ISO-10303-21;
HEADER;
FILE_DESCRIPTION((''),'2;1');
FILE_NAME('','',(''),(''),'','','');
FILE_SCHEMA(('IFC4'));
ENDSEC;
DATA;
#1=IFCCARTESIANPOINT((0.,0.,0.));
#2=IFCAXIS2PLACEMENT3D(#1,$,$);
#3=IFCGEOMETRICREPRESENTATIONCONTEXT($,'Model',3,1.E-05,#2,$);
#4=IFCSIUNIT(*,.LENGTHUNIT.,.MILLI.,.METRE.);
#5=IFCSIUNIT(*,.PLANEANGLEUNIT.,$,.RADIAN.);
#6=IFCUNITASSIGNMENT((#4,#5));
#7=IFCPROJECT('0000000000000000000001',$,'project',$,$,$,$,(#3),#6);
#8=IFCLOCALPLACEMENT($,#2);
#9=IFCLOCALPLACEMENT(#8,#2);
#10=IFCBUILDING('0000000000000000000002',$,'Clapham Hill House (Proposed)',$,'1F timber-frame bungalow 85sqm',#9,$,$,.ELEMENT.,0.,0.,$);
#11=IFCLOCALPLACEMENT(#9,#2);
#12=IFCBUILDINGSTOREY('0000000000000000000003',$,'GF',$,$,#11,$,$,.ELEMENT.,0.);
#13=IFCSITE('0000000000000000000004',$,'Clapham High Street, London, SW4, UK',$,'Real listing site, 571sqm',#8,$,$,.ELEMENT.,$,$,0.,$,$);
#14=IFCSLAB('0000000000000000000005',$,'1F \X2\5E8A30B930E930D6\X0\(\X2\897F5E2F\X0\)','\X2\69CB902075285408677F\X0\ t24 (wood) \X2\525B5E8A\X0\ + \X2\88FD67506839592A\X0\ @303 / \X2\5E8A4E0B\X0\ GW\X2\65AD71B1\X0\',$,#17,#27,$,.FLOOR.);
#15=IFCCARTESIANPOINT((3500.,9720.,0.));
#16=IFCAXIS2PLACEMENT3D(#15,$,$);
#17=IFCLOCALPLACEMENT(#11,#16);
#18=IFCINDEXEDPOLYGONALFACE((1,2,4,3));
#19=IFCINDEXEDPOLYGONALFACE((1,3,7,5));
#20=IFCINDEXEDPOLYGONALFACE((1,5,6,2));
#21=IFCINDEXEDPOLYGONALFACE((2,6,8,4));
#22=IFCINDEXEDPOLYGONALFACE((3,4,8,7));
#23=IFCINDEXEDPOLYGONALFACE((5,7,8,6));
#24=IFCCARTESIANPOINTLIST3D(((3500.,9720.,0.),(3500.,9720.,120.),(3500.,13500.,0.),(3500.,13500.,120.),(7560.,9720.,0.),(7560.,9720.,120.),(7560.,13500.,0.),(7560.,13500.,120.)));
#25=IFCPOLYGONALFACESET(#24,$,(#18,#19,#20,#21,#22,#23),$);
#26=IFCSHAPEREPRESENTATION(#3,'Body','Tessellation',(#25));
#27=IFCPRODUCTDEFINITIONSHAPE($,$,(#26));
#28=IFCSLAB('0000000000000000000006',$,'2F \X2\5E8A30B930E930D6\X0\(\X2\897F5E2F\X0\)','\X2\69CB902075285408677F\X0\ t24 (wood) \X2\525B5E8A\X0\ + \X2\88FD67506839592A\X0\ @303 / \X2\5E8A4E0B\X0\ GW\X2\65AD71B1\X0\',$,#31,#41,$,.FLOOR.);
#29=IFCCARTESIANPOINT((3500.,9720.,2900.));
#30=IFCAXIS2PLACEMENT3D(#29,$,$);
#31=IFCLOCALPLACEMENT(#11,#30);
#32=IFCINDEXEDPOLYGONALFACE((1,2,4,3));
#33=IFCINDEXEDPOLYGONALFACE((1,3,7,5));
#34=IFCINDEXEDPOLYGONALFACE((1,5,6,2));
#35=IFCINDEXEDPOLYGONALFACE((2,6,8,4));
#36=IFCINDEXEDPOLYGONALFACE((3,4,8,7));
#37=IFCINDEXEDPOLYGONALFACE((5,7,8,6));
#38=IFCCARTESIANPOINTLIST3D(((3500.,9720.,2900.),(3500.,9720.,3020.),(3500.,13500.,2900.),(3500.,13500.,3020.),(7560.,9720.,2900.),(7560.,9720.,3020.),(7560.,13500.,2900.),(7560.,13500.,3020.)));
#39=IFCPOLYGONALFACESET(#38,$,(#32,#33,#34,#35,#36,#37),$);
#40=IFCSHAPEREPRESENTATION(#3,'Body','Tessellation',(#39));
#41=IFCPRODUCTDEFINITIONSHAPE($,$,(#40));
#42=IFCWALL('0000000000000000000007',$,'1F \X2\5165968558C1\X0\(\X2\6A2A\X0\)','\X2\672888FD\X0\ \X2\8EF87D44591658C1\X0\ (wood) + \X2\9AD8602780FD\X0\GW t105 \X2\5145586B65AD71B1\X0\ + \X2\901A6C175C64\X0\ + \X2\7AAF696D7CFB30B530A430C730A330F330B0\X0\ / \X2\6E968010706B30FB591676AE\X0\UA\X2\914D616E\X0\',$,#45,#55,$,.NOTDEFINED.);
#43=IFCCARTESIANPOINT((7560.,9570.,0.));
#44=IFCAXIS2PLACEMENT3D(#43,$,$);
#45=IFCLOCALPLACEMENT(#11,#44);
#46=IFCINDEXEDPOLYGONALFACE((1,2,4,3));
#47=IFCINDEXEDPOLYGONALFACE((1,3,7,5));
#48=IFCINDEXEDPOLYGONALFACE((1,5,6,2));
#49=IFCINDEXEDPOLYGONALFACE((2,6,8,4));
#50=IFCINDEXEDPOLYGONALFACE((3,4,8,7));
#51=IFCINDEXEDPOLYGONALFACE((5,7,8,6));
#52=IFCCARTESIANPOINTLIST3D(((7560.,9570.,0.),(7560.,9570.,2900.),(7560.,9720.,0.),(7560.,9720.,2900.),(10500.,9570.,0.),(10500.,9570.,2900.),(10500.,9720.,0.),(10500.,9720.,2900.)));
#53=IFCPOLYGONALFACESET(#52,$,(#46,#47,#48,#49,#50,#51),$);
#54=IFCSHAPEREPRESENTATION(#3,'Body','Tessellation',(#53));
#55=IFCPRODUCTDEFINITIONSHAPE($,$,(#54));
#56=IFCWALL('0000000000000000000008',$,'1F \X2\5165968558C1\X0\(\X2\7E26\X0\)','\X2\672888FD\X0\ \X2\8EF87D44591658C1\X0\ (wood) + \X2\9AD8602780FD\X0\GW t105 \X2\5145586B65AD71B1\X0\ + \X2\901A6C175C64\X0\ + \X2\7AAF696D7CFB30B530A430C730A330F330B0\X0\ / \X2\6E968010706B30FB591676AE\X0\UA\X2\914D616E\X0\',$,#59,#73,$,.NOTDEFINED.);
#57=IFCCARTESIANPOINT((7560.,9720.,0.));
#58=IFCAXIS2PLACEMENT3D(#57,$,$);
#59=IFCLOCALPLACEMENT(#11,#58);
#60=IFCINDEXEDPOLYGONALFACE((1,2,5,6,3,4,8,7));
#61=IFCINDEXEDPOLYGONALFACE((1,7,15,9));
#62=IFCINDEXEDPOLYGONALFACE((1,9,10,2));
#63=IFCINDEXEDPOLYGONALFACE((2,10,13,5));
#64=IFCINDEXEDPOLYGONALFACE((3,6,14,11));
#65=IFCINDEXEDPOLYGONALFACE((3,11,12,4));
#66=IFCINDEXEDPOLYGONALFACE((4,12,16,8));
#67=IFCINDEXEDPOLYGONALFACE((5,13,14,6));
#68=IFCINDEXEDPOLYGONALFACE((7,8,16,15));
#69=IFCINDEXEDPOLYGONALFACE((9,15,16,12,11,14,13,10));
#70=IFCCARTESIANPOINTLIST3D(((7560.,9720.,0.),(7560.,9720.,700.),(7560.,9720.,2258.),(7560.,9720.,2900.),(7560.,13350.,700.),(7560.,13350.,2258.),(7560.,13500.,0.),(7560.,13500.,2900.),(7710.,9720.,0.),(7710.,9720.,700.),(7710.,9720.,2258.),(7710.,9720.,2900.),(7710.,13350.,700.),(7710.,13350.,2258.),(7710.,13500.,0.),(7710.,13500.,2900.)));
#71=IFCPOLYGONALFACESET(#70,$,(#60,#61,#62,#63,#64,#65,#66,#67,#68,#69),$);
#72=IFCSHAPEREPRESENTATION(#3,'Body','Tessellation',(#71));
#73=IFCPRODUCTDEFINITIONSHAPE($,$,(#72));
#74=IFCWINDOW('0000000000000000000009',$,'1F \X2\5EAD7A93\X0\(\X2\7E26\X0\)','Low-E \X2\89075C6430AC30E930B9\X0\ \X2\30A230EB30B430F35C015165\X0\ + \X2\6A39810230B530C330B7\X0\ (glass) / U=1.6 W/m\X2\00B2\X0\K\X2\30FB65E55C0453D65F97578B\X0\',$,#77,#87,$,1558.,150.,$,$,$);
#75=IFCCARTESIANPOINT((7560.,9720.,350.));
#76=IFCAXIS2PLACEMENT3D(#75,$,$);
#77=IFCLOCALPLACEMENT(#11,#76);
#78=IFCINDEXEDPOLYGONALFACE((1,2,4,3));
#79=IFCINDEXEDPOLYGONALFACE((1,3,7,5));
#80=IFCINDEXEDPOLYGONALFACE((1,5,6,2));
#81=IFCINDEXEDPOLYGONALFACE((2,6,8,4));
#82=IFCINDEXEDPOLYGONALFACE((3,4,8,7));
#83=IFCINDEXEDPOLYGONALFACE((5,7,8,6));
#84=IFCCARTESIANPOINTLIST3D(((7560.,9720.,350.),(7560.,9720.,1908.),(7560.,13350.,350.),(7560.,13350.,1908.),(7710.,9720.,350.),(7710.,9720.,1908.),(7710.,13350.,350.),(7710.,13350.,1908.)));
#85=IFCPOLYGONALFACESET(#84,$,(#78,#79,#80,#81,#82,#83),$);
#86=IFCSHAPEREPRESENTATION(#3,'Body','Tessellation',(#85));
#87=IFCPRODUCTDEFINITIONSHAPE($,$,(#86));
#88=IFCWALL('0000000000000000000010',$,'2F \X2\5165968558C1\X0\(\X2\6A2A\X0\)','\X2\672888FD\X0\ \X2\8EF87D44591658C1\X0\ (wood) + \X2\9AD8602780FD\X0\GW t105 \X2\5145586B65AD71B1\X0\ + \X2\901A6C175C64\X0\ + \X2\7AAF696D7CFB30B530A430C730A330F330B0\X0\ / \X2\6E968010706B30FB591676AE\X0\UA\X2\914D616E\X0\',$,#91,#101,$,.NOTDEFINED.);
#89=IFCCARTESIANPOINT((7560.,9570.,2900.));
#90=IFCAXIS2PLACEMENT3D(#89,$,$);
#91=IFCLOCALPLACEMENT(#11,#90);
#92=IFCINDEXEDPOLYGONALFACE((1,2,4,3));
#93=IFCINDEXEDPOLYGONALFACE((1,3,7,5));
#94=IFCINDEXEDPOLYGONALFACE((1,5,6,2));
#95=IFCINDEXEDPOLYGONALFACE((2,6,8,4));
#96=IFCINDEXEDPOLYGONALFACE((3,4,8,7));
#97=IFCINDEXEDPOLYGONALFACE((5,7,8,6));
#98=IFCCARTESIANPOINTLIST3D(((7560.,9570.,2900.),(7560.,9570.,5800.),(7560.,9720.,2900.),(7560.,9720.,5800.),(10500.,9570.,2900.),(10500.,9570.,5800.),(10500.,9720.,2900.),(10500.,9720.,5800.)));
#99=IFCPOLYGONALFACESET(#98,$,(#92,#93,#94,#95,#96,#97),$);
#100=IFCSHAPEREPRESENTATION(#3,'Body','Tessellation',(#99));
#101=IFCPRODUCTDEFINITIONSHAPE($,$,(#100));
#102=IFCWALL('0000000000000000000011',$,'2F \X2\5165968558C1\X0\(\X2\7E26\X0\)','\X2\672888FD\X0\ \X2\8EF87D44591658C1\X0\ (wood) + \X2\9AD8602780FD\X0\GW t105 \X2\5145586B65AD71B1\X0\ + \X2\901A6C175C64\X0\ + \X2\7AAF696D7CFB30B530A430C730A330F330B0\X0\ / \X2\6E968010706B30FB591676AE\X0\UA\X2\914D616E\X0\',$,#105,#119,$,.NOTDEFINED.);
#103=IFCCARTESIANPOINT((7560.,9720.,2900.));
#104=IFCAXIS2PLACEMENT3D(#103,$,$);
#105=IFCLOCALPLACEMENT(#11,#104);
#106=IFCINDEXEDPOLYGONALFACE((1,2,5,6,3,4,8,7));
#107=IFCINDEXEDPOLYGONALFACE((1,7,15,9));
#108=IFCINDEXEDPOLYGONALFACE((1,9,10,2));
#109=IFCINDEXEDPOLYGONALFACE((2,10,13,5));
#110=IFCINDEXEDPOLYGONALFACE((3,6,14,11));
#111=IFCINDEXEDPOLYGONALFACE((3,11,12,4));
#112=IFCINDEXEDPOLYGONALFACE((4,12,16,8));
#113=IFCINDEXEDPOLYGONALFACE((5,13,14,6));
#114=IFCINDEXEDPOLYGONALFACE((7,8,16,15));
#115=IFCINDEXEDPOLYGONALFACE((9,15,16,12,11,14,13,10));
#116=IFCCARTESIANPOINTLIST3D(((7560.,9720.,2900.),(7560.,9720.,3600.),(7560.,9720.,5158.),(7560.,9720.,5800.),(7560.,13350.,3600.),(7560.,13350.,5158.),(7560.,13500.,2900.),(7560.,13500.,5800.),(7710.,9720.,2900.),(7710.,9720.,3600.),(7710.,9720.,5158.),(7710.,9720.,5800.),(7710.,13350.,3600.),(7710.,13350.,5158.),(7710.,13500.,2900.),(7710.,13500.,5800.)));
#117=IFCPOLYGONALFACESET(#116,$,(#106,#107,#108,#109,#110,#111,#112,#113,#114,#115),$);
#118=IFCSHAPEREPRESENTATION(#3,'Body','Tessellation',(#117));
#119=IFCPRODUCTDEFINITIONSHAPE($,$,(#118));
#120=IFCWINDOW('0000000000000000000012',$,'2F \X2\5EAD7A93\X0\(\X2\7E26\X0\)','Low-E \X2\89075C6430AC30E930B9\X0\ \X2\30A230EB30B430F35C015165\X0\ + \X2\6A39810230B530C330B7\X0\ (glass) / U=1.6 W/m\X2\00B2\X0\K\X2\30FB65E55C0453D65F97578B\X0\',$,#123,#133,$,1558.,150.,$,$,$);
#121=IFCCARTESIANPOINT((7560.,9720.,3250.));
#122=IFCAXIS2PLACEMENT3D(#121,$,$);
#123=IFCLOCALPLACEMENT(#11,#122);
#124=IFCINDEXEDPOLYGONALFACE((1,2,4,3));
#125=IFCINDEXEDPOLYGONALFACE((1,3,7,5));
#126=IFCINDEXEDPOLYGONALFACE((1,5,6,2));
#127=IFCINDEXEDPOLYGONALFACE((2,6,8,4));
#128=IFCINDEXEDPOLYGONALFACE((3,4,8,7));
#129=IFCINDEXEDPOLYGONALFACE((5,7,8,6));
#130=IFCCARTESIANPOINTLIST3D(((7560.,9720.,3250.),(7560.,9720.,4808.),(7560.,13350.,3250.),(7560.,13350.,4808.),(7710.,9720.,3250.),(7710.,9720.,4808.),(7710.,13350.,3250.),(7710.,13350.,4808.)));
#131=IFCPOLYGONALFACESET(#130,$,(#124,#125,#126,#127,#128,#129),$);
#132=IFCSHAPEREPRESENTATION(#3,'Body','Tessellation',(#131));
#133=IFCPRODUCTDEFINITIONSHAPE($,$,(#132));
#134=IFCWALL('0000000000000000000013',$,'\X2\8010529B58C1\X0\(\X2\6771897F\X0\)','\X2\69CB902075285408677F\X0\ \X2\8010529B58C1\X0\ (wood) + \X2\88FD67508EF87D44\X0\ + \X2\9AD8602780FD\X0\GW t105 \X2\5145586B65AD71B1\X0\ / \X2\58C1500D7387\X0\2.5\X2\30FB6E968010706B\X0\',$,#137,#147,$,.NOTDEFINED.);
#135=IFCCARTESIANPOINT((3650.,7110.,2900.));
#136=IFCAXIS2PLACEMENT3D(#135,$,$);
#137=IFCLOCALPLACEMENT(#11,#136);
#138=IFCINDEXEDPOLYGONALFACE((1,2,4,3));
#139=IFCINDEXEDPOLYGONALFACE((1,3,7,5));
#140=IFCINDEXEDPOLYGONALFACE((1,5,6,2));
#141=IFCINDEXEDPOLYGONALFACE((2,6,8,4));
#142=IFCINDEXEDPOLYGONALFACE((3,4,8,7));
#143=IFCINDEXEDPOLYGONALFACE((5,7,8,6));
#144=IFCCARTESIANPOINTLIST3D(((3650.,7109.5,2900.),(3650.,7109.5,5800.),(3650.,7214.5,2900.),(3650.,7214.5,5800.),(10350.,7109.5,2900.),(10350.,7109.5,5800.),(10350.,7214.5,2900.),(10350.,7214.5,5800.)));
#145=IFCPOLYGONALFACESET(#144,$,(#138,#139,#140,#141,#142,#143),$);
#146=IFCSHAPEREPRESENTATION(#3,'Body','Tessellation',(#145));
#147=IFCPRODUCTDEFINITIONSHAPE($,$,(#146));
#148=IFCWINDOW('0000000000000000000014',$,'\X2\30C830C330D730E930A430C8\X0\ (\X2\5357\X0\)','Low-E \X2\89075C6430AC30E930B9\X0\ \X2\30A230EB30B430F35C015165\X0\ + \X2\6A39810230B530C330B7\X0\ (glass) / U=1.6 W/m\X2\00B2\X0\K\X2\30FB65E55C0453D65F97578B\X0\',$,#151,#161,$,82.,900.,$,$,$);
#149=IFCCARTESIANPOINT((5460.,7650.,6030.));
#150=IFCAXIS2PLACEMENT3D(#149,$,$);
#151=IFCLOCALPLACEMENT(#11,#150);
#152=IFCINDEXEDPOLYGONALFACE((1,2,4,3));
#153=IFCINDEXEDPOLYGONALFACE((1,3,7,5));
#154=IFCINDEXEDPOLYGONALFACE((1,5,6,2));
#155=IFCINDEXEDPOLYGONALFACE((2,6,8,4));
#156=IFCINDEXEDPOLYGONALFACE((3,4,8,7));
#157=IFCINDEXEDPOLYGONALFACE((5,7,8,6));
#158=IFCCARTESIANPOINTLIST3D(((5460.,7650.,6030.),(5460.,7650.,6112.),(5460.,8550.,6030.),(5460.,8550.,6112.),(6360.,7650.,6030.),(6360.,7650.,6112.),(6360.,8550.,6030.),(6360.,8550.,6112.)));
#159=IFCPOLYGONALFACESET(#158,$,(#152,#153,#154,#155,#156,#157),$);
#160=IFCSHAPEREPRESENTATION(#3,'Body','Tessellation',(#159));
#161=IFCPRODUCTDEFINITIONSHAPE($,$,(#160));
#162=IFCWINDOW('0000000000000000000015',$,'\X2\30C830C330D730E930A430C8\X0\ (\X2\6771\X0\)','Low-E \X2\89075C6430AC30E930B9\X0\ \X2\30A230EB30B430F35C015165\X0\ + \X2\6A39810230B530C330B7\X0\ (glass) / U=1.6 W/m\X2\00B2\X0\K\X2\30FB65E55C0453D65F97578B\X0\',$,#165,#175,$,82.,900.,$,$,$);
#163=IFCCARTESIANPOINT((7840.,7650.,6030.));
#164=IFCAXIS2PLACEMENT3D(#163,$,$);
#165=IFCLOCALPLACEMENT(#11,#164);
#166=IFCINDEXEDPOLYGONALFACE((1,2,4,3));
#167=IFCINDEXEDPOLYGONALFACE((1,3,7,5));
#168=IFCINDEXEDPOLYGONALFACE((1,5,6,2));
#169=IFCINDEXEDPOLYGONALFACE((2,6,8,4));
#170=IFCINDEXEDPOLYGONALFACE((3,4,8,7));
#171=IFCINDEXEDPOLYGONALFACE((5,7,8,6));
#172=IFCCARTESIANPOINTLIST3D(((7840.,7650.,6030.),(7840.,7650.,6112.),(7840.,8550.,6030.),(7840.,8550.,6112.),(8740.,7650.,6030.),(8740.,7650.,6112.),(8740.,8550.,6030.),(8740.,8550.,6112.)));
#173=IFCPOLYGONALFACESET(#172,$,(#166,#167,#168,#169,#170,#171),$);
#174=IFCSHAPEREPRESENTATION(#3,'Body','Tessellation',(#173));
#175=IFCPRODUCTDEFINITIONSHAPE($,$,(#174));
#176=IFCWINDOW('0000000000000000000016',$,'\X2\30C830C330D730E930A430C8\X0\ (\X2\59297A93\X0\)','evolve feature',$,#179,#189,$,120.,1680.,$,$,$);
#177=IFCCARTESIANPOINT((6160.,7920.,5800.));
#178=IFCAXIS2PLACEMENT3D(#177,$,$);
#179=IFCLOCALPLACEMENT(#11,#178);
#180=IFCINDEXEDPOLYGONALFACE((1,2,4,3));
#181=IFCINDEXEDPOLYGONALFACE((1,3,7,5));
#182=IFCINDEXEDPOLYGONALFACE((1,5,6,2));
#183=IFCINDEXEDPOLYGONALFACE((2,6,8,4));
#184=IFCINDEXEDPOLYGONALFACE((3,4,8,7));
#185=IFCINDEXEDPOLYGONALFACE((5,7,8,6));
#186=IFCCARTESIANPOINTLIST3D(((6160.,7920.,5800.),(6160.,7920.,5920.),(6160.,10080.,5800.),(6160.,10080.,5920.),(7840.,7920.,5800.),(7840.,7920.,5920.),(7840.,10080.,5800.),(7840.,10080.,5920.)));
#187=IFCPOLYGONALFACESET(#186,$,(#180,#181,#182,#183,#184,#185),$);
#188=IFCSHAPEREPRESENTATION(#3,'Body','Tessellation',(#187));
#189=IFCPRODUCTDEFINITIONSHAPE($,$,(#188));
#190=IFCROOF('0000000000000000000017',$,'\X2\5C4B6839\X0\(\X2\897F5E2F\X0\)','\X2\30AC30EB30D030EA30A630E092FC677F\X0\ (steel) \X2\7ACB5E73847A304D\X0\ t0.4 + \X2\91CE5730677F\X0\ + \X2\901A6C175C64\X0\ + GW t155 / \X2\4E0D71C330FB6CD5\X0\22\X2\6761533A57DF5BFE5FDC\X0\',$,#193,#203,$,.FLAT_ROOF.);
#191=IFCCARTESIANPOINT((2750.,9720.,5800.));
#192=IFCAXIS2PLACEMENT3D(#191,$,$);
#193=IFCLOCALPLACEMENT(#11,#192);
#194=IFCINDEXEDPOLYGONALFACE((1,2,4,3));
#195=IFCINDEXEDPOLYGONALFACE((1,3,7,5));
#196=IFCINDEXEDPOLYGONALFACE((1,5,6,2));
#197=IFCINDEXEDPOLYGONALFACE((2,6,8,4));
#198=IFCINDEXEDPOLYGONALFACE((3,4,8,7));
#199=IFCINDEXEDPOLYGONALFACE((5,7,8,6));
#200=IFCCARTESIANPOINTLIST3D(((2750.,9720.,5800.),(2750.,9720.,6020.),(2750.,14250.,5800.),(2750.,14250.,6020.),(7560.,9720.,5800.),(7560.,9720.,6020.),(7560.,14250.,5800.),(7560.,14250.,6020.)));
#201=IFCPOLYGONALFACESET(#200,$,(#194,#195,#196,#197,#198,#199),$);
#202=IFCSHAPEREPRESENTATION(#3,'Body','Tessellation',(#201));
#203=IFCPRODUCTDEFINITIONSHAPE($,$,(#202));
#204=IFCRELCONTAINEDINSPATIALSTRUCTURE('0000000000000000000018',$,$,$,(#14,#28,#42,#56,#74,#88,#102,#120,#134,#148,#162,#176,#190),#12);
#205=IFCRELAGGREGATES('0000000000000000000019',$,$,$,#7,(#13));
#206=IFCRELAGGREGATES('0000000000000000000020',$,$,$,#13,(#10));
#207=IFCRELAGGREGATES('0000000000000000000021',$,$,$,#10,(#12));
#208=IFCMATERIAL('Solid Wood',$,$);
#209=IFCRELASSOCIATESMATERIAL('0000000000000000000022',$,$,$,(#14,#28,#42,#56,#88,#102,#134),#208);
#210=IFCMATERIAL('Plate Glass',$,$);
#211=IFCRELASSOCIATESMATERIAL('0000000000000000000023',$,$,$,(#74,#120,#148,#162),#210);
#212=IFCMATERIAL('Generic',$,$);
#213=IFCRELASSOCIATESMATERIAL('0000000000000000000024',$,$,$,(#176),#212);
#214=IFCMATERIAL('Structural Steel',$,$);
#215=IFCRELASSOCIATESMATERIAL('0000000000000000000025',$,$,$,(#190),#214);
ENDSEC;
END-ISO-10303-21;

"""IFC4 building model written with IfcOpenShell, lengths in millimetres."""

from ifc_helpers import new_model, si_unit, frame, frame_2d, origin, place, context, project, spatial, rectangle, extrude, material, element, fill, save


model = new_model("IFC4")

# Units and contexts
model_context = context("Model", 3, precision=1e-05, world=origin())
ifc_project = project(units=[si_unit("LENGTHUNIT", "METRE", prefix="MILLI"), si_unit("PLANEANGLEUNIT", "RADIAN")], contexts=[model_context])

# Site, building, storey
site_placement = place(None, origin())
site = spatial("IfcSite", under=ifc_project, at=site_placement, Name="Clapham High Street, London, SW4, UK", ObjectType="Real listing site, 571sqm", CompositionType="ELEMENT", RefElevation=0.0)
building_placement = place(site_placement, origin())
building = spatial("IfcBuilding", under=site, at=building_placement, Name="Clapham Hill House (Proposed)", ObjectType="1F timber-frame bungalow 85sqm", CompositionType="ELEMENT", ElevationOfRefHeight=0.0, ElevationOfTerrain=0.0)
storey_placement = place(building_placement, origin())
storey = spatial("IfcBuildingStorey", under=building, at=storey_placement, Name="GF", CompositionType="ELEMENT", Elevation=0.0)

# Slabs
ifc_material_1 = material(Name="Solid Wood")
slab_1_placement = place(storey_placement, frame((3500.0, 9720.0, 0.0)))
element("IfcSlab", 1, at=slab_1_placement, inside=storey, material=ifc_material_1, Name="1F 床スラブ(西帯)", Description="構造用合板 t24 (wood) 剛床 + 製材根太 @303 / 床下 GW断熱", PredefinedType="FLOOR", context=model_context, shape_type="SweptSolid", body=[
    extrude(rectangle(XDim=4060.0, YDim=3780.0, at=frame_2d((2030.0, 1890.0))), frame((3500.0, 9720.0, 0.0)), (0.0, 0.0, 1.0), 120.0),
])
slab_2_placement = place(storey_placement, frame((3500.0, 9720.0, 2900.0)))
element("IfcSlab", 2, at=slab_2_placement, inside=storey, material=ifc_material_1, Name="2F 床スラブ(西帯)", Description="構造用合板 t24 (wood) 剛床 + 製材根太 @303 / 床下 GW断熱", PredefinedType="FLOOR", context=model_context, shape_type="SweptSolid", body=[
    extrude(rectangle(XDim=4060.0, YDim=3780.0, at=frame_2d((2030.0, 1890.0))), frame((3500.0, 9720.0, 2900.0)), (0.0, 0.0, 1.0), 120.0),
])

# Wall
wall_1_placement = place(storey_placement, frame((7560.0, 9570.0, 0.0)))
element("IfcWall", 3, at=wall_1_placement, inside=storey, material=ifc_material_1, Name="1F 入隅壁(横)", Description="木製 軸組外壁 (wood) + 高性能GW t105 充填断熱 + 通気層 + 窯業系サイディング / 準耐火・外皮UA配慮", PredefinedType="NOTDEFINED", context=model_context, shape_type="SweptSolid", body=[
    extrude(rectangle(XDim=2940.0, YDim=150.0, at=frame_2d((1470.0, 75.0))), frame((7560.0, 9570.0, 0.0)), (0.0, 0.0, 1.0), 2900.0),
])

# Wall, opening, window
wall_2_placement = place(storey_placement, frame((7560.0, 9720.0, 0.0)))
wall_2 = element("IfcWall", 4, at=wall_2_placement, inside=storey, material=ifc_material_1, Name="1F 入隅壁(縦)", Description="木製 軸組外壁 (wood) + 高性能GW t105 充填断熱 + 通気層 + 窯業系サイディング / 準耐火・外皮UA配慮", PredefinedType="NOTDEFINED", context=model_context, shape_type="SweptSolid", body=[
    extrude(rectangle(XDim=150.0, YDim=3780.0, at=frame_2d((75.0, 1890.0))), frame((7560.0, 9720.0, 0.0)), (0.0, 0.0, 1.0), 2900.0),
])
opening_1_placement = place(storey_placement, frame((7560.0, 9720.0, 350.0)))
opening_1 = element("IfcOpeningElement", 5, at=opening_1_placement, cuts=wall_2, PredefinedType="NOTDEFINED", context=model_context, shape_type="SweptSolid", body=[
    extrude(rectangle(XDim=150.0, YDim=3630.0, at=frame_2d((75.0, 1815.0))), frame((7560.0, 9720.0, 350.0)), (0.0, 0.0, 1.0), 1558.0),
])
ifc_material_2 = material(Name="Plate Glass")
window_1_placement = place(storey_placement, frame((7560.0, 9720.0, 350.0)))
window_1 = element("IfcWindow", 6, at=window_1_placement, inside=storey, material=ifc_material_2, Name="1F 庭窓(縦)", Description="Low-E 複層ガラス アルゴン封入 + 樹脂サッシ (glass) / U=1.6 W/m²K・日射取得型", OverallHeight=1558.0, OverallWidth=150.0, context=model_context, shape_type="SweptSolid", body=[
    extrude(rectangle(XDim=150.0, YDim=3630.0, at=frame_2d((75.0, 1815.0))), frame((7560.0, 9720.0, 350.0)), (0.0, 0.0, 1.0), 1558.0),
])
fill(opening_1, window_1)

# Wall
wall_3_placement = place(storey_placement, frame((7560.0, 9570.0, 2900.0)))
element("IfcWall", 7, at=wall_3_placement, inside=storey, material=ifc_material_1, Name="2F 入隅壁(横)", Description="木製 軸組外壁 (wood) + 高性能GW t105 充填断熱 + 通気層 + 窯業系サイディング / 準耐火・外皮UA配慮", PredefinedType="NOTDEFINED", context=model_context, shape_type="SweptSolid", body=[
    extrude(rectangle(XDim=2940.0, YDim=150.0, at=frame_2d((1470.0, 75.0))), frame((7560.0, 9570.0, 2900.0)), (0.0, 0.0, 1.0), 2900.0),
])

# Wall, opening, window
wall_4_placement = place(storey_placement, frame((7560.0, 9720.0, 2900.0)))
wall_4 = element("IfcWall", 8, at=wall_4_placement, inside=storey, material=ifc_material_1, Name="2F 入隅壁(縦)", Description="木製 軸組外壁 (wood) + 高性能GW t105 充填断熱 + 通気層 + 窯業系サイディング / 準耐火・外皮UA配慮", PredefinedType="NOTDEFINED", context=model_context, shape_type="SweptSolid", body=[
    extrude(rectangle(XDim=150.0, YDim=3780.0, at=frame_2d((75.0, 1890.0))), frame((7560.0, 9720.0, 2900.0)), (0.0, 0.0, 1.0), 2900.0),
])
opening_2_placement = place(storey_placement, frame((7560.0, 9720.0, 3250.0)))
opening_2 = element("IfcOpeningElement", 9, at=opening_2_placement, cuts=wall_4, PredefinedType="NOTDEFINED", context=model_context, shape_type="SweptSolid", body=[
    extrude(rectangle(XDim=150.0, YDim=3630.0, at=frame_2d((75.0, 1815.0))), frame((7560.0, 9720.0, 3250.0)), (0.0, 0.0, 1.0), 1558.0),
])
window_2_placement = place(storey_placement, frame((7560.0, 9720.0, 3250.0)))
window_2 = element("IfcWindow", 10, at=window_2_placement, inside=storey, material=ifc_material_2, Name="2F 庭窓(縦)", Description="Low-E 複層ガラス アルゴン封入 + 樹脂サッシ (glass) / U=1.6 W/m²K・日射取得型", OverallHeight=1558.0, OverallWidth=150.0, context=model_context, shape_type="SweptSolid", body=[
    extrude(rectangle(XDim=150.0, YDim=3630.0, at=frame_2d((75.0, 1815.0))), frame((7560.0, 9720.0, 3250.0)), (0.0, 0.0, 1.0), 1558.0),
])
fill(opening_2, window_2)

# Wall
wall_5_placement = place(storey_placement, frame((3650.0, 7110.0, 2900.0)))
element("IfcWall", 11, at=wall_5_placement, inside=storey, material=ifc_material_1, Name="耐力壁(東西)", Description="構造用合板 耐力壁 (wood) + 製材軸組 + 高性能GW t105 充填断熱 / 壁倍率2.5・準耐火", PredefinedType="NOTDEFINED", context=model_context, shape_type="SweptSolid", body=[
    extrude(rectangle(XDim=6700.0, YDim=105.0, at=frame_2d((3350.0, 52.0))), frame((3650.0, 7110.0, 2900.0)), (0.0, 0.0, 1.0), 2900.0),
])

# Windows
window_3_placement = place(storey_placement, frame((5460.0, 7650.0, 6030.0)))
element("IfcWindow", 12, at=window_3_placement, inside=storey, material=ifc_material_2, Name="トップライト (南)", Description="Low-E 複層ガラス アルゴン封入 + 樹脂サッシ (glass) / U=1.6 W/m²K・日射取得型", OverallHeight=82.0, OverallWidth=900.0, context=model_context, shape_type="SweptSolid", body=[
    extrude(rectangle(XDim=900.0, YDim=900.0, at=frame_2d((450.0, 450.0))), frame((5460.0, 7650.0, 6030.0)), (0.0, 0.0, 1.0), 82.0),
])
window_4_placement = place(storey_placement, frame((7840.0, 7650.0, 6030.0)))
element("IfcWindow", 13, at=window_4_placement, inside=storey, material=ifc_material_2, Name="トップライト (東)", Description="Low-E 複層ガラス アルゴン封入 + 樹脂サッシ (glass) / U=1.6 W/m²K・日射取得型", OverallHeight=82.0, OverallWidth=900.0, context=model_context, shape_type="SweptSolid", body=[
    extrude(rectangle(XDim=900.0, YDim=900.0, at=frame_2d((450.0, 450.0))), frame((7840.0, 7650.0, 6030.0)), (0.0, 0.0, 1.0), 82.0),
])
ifc_material_3 = material(Name="Generic")
window_5_placement = place(storey_placement, frame((6160.0, 7920.0, 5800.0)))
element("IfcWindow", 14, at=window_5_placement, inside=storey, material=ifc_material_3, Name="トップライト (天窓)", Description="evolve feature", OverallHeight=120.0, OverallWidth=1680.0, context=model_context, shape_type="SweptSolid", body=[
    extrude(rectangle(XDim=1680.0, YDim=2160.0, at=frame_2d((840.0, 1080.0))), frame((6160.0, 7920.0, 5800.0)), (0.0, 0.0, 1.0), 120.0),
])

# Roof
ifc_material_4 = material(Name="Structural Steel")
for number, where, name in (
    (15, (2750.0, 9720.0, 5800.0), "屋根(西帯)"),
):
    element("IfcRoof", number, at=place(storey_placement, frame(where)), inside=storey, material=ifc_material_4, Name=name, Description="ガルバリウム鋼板 (steel) 立平葺き t0.4 + 野地板 + 通気層 + GW t155 / 不燃・法22条区域対応", PredefinedType="FLAT_ROOF", context=model_context, shape_type="SweptSolid", body=[
        extrude(rectangle(XDim=4810.0, YDim=4530.0, at=frame_2d((2405.0, 2265.0))), frame((2750.0, 9720.0, 5800.0)), (0.0, 0.0, 1.0), 220.0),
    ])

save(model, "model.ifc")
